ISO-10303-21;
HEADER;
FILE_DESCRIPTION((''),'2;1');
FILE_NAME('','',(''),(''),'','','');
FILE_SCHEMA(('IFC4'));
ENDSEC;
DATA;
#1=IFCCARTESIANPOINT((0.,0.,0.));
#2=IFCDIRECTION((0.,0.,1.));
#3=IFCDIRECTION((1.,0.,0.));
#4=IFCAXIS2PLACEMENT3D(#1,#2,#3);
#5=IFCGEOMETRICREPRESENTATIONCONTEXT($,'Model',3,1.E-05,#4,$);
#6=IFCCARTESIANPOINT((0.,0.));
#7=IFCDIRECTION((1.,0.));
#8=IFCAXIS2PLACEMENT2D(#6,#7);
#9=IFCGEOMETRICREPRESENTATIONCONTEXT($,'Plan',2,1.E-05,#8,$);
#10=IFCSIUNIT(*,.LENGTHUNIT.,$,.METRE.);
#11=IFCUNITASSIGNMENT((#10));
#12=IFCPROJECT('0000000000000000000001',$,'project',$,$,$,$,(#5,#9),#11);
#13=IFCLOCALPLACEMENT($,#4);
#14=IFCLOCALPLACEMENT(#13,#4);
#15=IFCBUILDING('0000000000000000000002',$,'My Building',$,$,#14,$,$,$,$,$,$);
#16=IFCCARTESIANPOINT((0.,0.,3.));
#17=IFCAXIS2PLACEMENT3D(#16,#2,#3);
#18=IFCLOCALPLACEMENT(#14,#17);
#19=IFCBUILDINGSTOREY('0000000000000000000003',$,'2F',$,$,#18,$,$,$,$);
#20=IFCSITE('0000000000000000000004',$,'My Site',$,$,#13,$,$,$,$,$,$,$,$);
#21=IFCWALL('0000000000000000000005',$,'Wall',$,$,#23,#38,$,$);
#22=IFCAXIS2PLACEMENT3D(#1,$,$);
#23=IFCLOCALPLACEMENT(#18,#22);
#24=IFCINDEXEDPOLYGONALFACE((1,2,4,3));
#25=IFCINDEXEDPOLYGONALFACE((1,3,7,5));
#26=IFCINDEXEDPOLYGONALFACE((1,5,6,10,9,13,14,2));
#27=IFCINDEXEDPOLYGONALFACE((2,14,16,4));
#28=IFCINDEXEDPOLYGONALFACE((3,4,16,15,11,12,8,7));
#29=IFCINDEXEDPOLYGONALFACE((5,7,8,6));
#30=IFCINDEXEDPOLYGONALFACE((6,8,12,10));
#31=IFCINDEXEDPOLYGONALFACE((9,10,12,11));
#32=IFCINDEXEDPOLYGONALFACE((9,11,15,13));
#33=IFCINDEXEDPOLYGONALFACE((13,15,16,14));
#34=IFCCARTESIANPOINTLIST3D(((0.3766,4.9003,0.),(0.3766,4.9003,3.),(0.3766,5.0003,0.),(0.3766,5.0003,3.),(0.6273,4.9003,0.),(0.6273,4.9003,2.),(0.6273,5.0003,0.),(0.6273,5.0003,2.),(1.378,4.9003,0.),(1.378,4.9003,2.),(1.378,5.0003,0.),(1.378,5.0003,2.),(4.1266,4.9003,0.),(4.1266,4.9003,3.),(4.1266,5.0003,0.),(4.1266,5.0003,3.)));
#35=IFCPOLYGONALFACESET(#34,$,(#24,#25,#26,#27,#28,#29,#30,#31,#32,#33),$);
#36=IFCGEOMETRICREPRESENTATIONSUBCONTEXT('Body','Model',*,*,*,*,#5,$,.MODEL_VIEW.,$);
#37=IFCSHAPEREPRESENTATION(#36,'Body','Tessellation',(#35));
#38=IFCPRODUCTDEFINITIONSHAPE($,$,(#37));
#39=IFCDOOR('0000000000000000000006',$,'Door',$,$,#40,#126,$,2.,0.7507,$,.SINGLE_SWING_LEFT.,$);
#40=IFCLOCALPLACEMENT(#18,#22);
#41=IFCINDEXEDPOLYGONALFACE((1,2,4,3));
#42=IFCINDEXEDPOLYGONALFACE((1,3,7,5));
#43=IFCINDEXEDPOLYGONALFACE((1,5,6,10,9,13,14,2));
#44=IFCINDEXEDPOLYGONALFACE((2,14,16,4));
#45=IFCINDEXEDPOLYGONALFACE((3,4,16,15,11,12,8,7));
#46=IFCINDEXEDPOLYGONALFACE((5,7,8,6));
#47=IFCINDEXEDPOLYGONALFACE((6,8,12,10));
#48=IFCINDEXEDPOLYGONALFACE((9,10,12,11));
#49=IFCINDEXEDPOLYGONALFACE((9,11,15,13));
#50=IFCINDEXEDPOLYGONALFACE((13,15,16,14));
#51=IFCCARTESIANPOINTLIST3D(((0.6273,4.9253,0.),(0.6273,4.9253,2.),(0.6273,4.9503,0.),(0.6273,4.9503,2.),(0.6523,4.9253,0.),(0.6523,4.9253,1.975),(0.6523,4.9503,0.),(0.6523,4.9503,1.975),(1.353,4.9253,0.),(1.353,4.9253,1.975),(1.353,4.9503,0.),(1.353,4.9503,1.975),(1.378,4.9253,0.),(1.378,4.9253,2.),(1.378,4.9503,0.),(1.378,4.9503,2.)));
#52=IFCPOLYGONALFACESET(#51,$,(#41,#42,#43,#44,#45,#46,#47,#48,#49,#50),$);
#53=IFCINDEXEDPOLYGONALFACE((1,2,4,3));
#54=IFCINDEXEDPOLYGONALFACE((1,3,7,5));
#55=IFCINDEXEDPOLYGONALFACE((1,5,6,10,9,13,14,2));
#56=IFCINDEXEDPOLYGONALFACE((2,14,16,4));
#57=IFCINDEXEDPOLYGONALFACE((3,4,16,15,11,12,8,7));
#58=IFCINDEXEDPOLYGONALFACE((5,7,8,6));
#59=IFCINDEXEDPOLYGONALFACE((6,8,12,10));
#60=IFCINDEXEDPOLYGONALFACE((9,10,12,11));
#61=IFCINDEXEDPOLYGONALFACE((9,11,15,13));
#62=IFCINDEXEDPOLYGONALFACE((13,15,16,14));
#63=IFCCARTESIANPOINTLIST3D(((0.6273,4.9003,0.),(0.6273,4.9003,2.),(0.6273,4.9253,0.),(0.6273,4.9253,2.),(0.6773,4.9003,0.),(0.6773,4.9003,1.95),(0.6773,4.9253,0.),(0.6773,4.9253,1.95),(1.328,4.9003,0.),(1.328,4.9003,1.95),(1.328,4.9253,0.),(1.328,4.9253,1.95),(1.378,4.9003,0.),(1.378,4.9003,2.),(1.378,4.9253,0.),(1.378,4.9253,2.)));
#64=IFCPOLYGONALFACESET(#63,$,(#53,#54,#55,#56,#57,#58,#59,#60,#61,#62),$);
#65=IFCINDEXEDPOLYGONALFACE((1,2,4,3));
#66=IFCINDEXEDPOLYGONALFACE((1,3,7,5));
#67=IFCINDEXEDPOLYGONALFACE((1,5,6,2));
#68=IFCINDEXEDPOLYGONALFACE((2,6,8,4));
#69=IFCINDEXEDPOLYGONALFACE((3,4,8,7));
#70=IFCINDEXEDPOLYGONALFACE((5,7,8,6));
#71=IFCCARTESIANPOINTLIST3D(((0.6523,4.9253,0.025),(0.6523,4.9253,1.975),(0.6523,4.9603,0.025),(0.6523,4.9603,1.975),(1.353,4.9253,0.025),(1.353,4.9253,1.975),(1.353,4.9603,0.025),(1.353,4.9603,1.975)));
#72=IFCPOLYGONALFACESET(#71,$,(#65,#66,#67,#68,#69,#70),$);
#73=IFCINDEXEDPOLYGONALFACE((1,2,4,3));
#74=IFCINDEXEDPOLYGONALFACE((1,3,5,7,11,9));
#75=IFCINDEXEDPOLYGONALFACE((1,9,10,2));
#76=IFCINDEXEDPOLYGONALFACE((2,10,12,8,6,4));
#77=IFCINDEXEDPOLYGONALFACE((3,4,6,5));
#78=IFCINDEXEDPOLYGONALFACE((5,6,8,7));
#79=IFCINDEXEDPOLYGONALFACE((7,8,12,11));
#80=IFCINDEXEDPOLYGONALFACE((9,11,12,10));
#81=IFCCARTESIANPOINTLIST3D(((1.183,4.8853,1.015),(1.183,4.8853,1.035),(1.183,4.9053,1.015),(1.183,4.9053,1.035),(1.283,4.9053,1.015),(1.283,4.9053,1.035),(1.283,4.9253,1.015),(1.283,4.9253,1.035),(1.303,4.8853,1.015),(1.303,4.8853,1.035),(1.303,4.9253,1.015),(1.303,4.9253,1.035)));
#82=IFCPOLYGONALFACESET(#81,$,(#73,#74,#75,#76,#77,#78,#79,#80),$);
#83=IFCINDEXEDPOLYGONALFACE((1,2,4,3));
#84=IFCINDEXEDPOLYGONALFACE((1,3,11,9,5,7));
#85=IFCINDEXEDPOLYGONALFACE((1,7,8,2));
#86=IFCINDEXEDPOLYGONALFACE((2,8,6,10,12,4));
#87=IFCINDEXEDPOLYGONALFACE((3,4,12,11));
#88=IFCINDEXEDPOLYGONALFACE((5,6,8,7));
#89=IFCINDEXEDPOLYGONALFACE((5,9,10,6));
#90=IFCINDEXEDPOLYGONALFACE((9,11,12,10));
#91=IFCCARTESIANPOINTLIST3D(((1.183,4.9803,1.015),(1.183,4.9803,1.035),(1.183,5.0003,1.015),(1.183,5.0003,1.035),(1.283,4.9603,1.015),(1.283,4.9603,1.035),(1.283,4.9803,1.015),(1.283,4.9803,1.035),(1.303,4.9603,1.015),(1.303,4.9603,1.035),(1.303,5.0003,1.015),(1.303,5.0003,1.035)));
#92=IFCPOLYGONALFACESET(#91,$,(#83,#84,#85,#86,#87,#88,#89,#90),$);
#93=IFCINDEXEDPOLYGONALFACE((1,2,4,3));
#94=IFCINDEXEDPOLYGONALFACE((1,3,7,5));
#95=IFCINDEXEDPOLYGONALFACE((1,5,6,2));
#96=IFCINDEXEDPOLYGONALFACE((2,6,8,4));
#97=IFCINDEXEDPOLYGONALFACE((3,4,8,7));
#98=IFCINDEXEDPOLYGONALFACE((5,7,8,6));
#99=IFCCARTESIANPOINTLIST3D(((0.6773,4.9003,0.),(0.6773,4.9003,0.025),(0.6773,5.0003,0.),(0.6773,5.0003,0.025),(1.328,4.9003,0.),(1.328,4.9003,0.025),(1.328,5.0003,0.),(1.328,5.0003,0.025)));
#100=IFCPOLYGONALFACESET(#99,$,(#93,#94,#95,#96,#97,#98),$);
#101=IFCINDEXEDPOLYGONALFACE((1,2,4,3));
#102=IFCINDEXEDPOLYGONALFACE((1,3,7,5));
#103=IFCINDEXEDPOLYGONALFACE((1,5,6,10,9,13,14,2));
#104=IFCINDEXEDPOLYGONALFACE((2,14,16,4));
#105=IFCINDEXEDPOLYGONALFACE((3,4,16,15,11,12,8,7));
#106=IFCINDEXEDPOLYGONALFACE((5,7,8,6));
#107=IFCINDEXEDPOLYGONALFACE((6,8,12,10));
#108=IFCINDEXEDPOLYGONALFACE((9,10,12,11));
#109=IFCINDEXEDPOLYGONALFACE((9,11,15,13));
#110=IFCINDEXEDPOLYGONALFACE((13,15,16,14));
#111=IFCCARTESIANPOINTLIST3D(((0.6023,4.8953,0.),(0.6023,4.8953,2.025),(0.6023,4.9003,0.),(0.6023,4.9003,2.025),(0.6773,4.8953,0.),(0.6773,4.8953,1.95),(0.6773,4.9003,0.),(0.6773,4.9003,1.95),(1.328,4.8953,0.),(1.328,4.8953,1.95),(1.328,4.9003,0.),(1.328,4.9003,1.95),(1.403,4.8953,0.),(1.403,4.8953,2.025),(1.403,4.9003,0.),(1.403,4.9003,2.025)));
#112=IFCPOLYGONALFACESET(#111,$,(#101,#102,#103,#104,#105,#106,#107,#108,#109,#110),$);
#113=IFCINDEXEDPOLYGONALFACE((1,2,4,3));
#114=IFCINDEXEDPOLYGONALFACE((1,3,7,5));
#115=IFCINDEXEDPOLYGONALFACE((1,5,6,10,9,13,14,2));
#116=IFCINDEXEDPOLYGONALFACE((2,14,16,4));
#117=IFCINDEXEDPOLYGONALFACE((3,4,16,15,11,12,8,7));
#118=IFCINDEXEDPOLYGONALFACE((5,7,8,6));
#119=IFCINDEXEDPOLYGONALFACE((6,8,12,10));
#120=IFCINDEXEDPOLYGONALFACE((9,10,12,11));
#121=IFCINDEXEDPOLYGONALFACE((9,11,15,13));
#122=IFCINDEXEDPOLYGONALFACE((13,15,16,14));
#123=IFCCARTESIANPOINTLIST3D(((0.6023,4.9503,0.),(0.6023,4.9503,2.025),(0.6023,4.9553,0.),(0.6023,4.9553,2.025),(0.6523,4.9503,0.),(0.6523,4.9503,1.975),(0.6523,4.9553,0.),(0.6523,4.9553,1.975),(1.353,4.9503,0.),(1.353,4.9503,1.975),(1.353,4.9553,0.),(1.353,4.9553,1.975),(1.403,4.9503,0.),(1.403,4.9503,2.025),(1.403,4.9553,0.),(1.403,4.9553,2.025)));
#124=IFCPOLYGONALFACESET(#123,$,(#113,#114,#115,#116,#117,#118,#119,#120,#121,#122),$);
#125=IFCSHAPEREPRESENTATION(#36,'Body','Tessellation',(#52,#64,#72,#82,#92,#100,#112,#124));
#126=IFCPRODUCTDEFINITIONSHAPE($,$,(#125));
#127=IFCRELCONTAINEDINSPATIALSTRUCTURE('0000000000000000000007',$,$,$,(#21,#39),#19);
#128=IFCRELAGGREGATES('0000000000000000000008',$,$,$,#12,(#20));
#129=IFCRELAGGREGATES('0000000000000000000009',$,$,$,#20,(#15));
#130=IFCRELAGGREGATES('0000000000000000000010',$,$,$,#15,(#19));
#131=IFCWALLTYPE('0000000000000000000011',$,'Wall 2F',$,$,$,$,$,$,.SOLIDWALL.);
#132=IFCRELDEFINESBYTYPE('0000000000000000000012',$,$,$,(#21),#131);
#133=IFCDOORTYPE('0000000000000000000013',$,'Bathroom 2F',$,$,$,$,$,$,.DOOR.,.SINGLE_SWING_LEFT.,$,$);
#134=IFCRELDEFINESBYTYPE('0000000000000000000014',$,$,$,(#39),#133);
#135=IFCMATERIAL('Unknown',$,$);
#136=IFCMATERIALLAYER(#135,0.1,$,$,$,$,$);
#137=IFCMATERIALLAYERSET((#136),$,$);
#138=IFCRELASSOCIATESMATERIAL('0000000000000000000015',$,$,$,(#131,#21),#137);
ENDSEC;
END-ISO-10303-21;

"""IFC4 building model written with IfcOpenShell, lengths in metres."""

from ifc_helpers import new_model, entity, si_unit, frame, origin_with_axes, origin_2d_with_axis, place, context, subcontext, project, spatial, line, indexed_curve, outline, extrude, shape, source, transform, mapped, material, layer, layer_set, layer_usage, type_object, type_shapes, element, fill, save


model = new_model("IFC4")

# Units and contexts
model_context = context("Model", 3, precision=1e-05, world=origin_with_axes())
plan_context = context("Plan", 2, precision=1e-05, world=origin_2d_with_axis())
body_context_1 = subcontext(model_context, "Body", "Model", "MODEL_VIEW")
body_context_2 = subcontext(plan_context, "Body", "Plan", "PLAN_VIEW")
ifc_project = project(units=[si_unit("LENGTHUNIT", "METRE")], contexts=[model_context, plan_context])

# Site, building, storey
site_placement = place(None, origin_with_axes())
site = spatial("IfcSite", under=ifc_project, at=site_placement, Name="My Site")
building_placement = place(site_placement, origin_with_axes())
building = spatial("IfcBuilding", under=site, at=building_placement, Name="My Building")
storey_placement = place(building_placement, frame((0.0, 0.0, 3.0), z_axis=(0.0, 0.0, 1.0), x_axis=(1.0, 0.0, 0.0)))
storey = spatial("IfcBuildingStorey", under=building, at=storey_placement, Name="2F")

# Shared definitions
ifc_material = material(Name="Unknown")

# Shared definitions
ifc_layer = layer(ifc_material, 0.1)
ifc_layer_set = layer_set([ifc_layer])
wall_type = type_object("IfcWallType", Name="Wall 2F", PredefinedType="SOLIDWALL", material=ifc_layer_set)

# Wall, opening, door
ifc_layer_usage_1 = layer_usage(ifc_layer_set, "AXIS2", "POSITIVE", 0.0)
wall_1_placement = place(storey_placement, frame((4.2266, 5.0003, 0.0), z_axis=(0.0, 0.0, 1.0), x_axis=(-1.0, 0.0, 0.0)))
wall_1 = element("IfcWall", 1, at=wall_1_placement, inside=storey, type_object=wall_type, material=ifc_layer_usage_1, Name="Wall", context=body_context_1, shape_type="SweptSolid", body=[
    extrude(outline(indexed_curve([(0.1, 0.0), (0.1, 0.1), (3.85, 0.1), (3.85, 0.0)], segments=[line(1, 2, 3, 4, 1)])), origin_with_axes(), (0.0, 0.0, 1.0), 3.0),
])
shared_shape_1 = source(origin_with_axes(), body_context_1, "Body", "SweptSolid", [
    extrude(outline(indexed_curve([(0.0, 0.0), (0.7507, 0.0), (0.7507, 2.0), (0.0, 2.0)], segments=[line(1, 2, 3, 4, 1)])), frame((0.0, -0.6, 0.0), z_axis=(0.0, -1.0, 0.0), x_axis=(1.0, 0.0, 0.0)), (0.0, 0.0, -1.0), 1.2),
])
opening_1_placement = place(wall_1_placement, frame((3.5993, 0.1, 0.0), z_axis=(0.0, 0.0, 1.0), x_axis=(-1.0, 0.000001, 0.0)))
opening_1 = element("IfcOpeningElement", 2, at=opening_1_placement, cuts=wall_1, PredefinedType="OPENING", context=body_context_1, shape_type="MappedRepresentation", body=[
    mapped(shared_shape_1, transform((0.0, 0.0, 0.0), x_axis=(1.0, 0.0, 0.0), y_axis=(0.0, 1.0, 0.0), z_axis=(0.0, 0.0, 1.0), scale=1.0)),
])
door_type = type_object("IfcDoorType", Name="Bathroom 2F", OperationType="SINGLE_SWING_LEFT", PredefinedType="DOOR")
shared_shape_2 = source(origin_with_axes(), body_context_1, "Body", "SweptSolid", [
    extrude(outline(indexed_curve([(0.0, 0.0), (0.0, 2.0), (0.7507, 2.0), (0.7507, 0.0), (0.7257, 0.0), (0.7257, 1.975), (0.025, 1.975), (0.025, 0.0)], segments=[line(1, 2, 3, 4, 5, 6, 7, 8, 1)])), frame((0.0, 0.025, 0.0), z_axis=(0.0, -1.0, 0.0), x_axis=(1.0, 0.0, 0.0)), (0.0, 0.0, -1.0), 0.025),
    extrude(outline(indexed_curve([(0.0, 0.0), (0.0, 2.0), (0.7507, 2.0), (0.7507, 0.0), (0.7007, 0.0), (0.7007, 1.95), (0.05, 1.95), (0.05, 0.0)], segments=[line(1, 2, 3, 4, 5, 6, 7, 8, 1)])), frame((0.0, 0.0, 0.0), z_axis=(0.0, -1.0, 0.0), x_axis=(1.0, 0.0, 0.0)), (0.0, 0.0, -1.0), 0.025),
    extrude(outline(indexed_curve([(0.0, 0.0), (0.7007, 0.0), (0.7007, 0.035), (0.0, 0.035)], segments=[line(1, 2, 3, 4, 1)])), frame((0.025, 0.025, 0.025), z_axis=(0.0, 0.0, 1.0), x_axis=(1.0, 0.0, 0.0)), (0.0, 0.0, 1.0), 1.95),
    extrude(outline(indexed_curve([(0.0, 0.0), (0.0, -0.04), (-0.12, -0.04), (-0.12, -0.02), (-0.02, -0.02), (-0.02, 0.0)], segments=[line(1, 2, 3, 4, 5, 6, 1)])), frame((0.6757, 0.025, 1.015), z_axis=(0.0, 0.0, 1.0), x_axis=(1.0, 0.0, 0.0)), (0.0, 0.0, 1.0), 0.02),
    extrude(outline(indexed_curve([(0.0, 0.0), (0.0, 0.04), (-0.12, 0.04), (-0.12, 0.02), (-0.02, 0.02), (-0.02, 0.0)], segments=[line(1, 2, 3, 4, 5, 6, 1)])), frame((0.6757, 0.06, 1.015), z_axis=(0.0, 0.0, 1.0), x_axis=(1.0, 0.0, 0.0)), (0.0, 0.0, 1.0), 0.02),
    extrude(outline(indexed_curve([(0.0, 0.0), (0.6507, 0.0), (0.6507, 0.1), (0.0, 0.1)], segments=[line(1, 2, 3, 4, 1)])), frame((0.05, 0.0, 0.0), z_axis=(0.0, 0.0, 1.0), x_axis=(1.0, 0.0, 0.0)), (0.0, 0.0, 1.0), 0.025),
    extrude(outline(indexed_curve([(0.0, 0.0), (0.0, 2.025), (0.8007, 2.025), (0.8007, 0.0), (0.7257, 0.0), (0.7257, 1.95), (0.075, 1.95), (0.075, 0.0)], segments=[line(1, 2, 3, 4, 5, 6, 7, 8, 1)])), frame((-0.025, -0.005, 0.0), z_axis=(0.0, -1.0, 0.0), x_axis=(1.0, 0.0, 0.0)), (0.0, 0.0, -1.0), 0.005),
    extrude(outline(indexed_curve([(0.0, 0.0), (0.0, 2.025), (0.8007, 2.025), (0.8007, 0.0), (0.7507, 0.0), (0.7507, 1.975), (0.05, 1.975), (0.05, 0.0)], segments=[line(1, 2, 3, 4, 5, 6, 7, 8, 1)])), frame((-0.025, 0.05, 0.0), z_axis=(0.0, -1.0, 0.0), x_axis=(1.0, 0.0, 0.0)), (0.0, 0.0, -1.0), 0.005),
])
shared_shape_3 = source(origin_with_axes(), body_context_2, "Body", "Curve2D", [
    entity("IfcIndexedPolyCurve", entity("IfcCartesianPointList2D", [[0.0, 0.0], [0.0, 0.05], [0.025, 0.05], [0.025, 0.025], [0.05, 0.025], [0.05, 0.0]]), [entity("IfcLineIndex", [1, 2, 3, 4, 5, 6, 1])]),
    entity("IfcIndexedPolyCurve", entity("IfcCartesianPointList2D", [[0.7507, 0.0], [0.7507, 0.05], [0.7257, 0.05], [0.7257, 0.025], [0.7007, 0.025], [0.7007, 0.0]]), [entity("IfcLineIndex", [1, 2, 3, 4, 5, 6, 1])]),
    entity("IfcTrimmedCurve", entity("IfcEllipse", entity("IfcAxis2Placement2D", entity("IfcCartesianPoint", [0.06, 0.05]), entity("IfcDirection", [1.0, 0.0])), 0.6657, 0.7007), [entity("IfcCartesianPoint", [0.7257, 0.05])], [entity("IfcCartesianPoint", [0.06, 0.7507])], True, "CARTESIAN"),
    entity("IfcIndexedPolyCurve", entity("IfcCartesianPointList2D", [[0.025, 0.05], [0.06, 0.05], [0.06, 0.7507], [0.025, 0.7507]]), [entity("IfcLineIndex", [1, 2, 3, 4, 1])]),
])
type_shapes(door_type, [shared_shape_2, shared_shape_3])
door_placement = place(opening_1_placement, frame((0.0, 0.0, 0.0), z_axis=(0.0, 0.0, 1.0), x_axis=(1.0, 0.0, 0.0)))
door = element("IfcDoor", 3, at=door_placement, inside=storey, type_object=door_type, Name="Door", OperationType="SINGLE_SWING_LEFT", OverallHeight=2.0, OverallWidth=0.7507, shapes=[
    shape(body_context_1, "Body", "MappedRepresentation", [mapped(shared_shape_2, transform((0.0, 0.0, 0.0), x_axis=(1.0, 0.0, 0.0), y_axis=(0.0, 1.0, 0.0), z_axis=(0.0, 0.0, 1.0), scale=1.0))]),
    shape(body_context_2, "Body", "MappedRepresentation", [mapped(shared_shape_3, transform((0.0, 0.0, 0.0), x_axis=(1.0, 0.0, 0.0), y_axis=(0.0, 1.0, 0.0), z_axis=(0.0, 0.0, 1.0), scale=1.0))]),
])
fill(opening_1, door)

save(model, "model.ifc")
